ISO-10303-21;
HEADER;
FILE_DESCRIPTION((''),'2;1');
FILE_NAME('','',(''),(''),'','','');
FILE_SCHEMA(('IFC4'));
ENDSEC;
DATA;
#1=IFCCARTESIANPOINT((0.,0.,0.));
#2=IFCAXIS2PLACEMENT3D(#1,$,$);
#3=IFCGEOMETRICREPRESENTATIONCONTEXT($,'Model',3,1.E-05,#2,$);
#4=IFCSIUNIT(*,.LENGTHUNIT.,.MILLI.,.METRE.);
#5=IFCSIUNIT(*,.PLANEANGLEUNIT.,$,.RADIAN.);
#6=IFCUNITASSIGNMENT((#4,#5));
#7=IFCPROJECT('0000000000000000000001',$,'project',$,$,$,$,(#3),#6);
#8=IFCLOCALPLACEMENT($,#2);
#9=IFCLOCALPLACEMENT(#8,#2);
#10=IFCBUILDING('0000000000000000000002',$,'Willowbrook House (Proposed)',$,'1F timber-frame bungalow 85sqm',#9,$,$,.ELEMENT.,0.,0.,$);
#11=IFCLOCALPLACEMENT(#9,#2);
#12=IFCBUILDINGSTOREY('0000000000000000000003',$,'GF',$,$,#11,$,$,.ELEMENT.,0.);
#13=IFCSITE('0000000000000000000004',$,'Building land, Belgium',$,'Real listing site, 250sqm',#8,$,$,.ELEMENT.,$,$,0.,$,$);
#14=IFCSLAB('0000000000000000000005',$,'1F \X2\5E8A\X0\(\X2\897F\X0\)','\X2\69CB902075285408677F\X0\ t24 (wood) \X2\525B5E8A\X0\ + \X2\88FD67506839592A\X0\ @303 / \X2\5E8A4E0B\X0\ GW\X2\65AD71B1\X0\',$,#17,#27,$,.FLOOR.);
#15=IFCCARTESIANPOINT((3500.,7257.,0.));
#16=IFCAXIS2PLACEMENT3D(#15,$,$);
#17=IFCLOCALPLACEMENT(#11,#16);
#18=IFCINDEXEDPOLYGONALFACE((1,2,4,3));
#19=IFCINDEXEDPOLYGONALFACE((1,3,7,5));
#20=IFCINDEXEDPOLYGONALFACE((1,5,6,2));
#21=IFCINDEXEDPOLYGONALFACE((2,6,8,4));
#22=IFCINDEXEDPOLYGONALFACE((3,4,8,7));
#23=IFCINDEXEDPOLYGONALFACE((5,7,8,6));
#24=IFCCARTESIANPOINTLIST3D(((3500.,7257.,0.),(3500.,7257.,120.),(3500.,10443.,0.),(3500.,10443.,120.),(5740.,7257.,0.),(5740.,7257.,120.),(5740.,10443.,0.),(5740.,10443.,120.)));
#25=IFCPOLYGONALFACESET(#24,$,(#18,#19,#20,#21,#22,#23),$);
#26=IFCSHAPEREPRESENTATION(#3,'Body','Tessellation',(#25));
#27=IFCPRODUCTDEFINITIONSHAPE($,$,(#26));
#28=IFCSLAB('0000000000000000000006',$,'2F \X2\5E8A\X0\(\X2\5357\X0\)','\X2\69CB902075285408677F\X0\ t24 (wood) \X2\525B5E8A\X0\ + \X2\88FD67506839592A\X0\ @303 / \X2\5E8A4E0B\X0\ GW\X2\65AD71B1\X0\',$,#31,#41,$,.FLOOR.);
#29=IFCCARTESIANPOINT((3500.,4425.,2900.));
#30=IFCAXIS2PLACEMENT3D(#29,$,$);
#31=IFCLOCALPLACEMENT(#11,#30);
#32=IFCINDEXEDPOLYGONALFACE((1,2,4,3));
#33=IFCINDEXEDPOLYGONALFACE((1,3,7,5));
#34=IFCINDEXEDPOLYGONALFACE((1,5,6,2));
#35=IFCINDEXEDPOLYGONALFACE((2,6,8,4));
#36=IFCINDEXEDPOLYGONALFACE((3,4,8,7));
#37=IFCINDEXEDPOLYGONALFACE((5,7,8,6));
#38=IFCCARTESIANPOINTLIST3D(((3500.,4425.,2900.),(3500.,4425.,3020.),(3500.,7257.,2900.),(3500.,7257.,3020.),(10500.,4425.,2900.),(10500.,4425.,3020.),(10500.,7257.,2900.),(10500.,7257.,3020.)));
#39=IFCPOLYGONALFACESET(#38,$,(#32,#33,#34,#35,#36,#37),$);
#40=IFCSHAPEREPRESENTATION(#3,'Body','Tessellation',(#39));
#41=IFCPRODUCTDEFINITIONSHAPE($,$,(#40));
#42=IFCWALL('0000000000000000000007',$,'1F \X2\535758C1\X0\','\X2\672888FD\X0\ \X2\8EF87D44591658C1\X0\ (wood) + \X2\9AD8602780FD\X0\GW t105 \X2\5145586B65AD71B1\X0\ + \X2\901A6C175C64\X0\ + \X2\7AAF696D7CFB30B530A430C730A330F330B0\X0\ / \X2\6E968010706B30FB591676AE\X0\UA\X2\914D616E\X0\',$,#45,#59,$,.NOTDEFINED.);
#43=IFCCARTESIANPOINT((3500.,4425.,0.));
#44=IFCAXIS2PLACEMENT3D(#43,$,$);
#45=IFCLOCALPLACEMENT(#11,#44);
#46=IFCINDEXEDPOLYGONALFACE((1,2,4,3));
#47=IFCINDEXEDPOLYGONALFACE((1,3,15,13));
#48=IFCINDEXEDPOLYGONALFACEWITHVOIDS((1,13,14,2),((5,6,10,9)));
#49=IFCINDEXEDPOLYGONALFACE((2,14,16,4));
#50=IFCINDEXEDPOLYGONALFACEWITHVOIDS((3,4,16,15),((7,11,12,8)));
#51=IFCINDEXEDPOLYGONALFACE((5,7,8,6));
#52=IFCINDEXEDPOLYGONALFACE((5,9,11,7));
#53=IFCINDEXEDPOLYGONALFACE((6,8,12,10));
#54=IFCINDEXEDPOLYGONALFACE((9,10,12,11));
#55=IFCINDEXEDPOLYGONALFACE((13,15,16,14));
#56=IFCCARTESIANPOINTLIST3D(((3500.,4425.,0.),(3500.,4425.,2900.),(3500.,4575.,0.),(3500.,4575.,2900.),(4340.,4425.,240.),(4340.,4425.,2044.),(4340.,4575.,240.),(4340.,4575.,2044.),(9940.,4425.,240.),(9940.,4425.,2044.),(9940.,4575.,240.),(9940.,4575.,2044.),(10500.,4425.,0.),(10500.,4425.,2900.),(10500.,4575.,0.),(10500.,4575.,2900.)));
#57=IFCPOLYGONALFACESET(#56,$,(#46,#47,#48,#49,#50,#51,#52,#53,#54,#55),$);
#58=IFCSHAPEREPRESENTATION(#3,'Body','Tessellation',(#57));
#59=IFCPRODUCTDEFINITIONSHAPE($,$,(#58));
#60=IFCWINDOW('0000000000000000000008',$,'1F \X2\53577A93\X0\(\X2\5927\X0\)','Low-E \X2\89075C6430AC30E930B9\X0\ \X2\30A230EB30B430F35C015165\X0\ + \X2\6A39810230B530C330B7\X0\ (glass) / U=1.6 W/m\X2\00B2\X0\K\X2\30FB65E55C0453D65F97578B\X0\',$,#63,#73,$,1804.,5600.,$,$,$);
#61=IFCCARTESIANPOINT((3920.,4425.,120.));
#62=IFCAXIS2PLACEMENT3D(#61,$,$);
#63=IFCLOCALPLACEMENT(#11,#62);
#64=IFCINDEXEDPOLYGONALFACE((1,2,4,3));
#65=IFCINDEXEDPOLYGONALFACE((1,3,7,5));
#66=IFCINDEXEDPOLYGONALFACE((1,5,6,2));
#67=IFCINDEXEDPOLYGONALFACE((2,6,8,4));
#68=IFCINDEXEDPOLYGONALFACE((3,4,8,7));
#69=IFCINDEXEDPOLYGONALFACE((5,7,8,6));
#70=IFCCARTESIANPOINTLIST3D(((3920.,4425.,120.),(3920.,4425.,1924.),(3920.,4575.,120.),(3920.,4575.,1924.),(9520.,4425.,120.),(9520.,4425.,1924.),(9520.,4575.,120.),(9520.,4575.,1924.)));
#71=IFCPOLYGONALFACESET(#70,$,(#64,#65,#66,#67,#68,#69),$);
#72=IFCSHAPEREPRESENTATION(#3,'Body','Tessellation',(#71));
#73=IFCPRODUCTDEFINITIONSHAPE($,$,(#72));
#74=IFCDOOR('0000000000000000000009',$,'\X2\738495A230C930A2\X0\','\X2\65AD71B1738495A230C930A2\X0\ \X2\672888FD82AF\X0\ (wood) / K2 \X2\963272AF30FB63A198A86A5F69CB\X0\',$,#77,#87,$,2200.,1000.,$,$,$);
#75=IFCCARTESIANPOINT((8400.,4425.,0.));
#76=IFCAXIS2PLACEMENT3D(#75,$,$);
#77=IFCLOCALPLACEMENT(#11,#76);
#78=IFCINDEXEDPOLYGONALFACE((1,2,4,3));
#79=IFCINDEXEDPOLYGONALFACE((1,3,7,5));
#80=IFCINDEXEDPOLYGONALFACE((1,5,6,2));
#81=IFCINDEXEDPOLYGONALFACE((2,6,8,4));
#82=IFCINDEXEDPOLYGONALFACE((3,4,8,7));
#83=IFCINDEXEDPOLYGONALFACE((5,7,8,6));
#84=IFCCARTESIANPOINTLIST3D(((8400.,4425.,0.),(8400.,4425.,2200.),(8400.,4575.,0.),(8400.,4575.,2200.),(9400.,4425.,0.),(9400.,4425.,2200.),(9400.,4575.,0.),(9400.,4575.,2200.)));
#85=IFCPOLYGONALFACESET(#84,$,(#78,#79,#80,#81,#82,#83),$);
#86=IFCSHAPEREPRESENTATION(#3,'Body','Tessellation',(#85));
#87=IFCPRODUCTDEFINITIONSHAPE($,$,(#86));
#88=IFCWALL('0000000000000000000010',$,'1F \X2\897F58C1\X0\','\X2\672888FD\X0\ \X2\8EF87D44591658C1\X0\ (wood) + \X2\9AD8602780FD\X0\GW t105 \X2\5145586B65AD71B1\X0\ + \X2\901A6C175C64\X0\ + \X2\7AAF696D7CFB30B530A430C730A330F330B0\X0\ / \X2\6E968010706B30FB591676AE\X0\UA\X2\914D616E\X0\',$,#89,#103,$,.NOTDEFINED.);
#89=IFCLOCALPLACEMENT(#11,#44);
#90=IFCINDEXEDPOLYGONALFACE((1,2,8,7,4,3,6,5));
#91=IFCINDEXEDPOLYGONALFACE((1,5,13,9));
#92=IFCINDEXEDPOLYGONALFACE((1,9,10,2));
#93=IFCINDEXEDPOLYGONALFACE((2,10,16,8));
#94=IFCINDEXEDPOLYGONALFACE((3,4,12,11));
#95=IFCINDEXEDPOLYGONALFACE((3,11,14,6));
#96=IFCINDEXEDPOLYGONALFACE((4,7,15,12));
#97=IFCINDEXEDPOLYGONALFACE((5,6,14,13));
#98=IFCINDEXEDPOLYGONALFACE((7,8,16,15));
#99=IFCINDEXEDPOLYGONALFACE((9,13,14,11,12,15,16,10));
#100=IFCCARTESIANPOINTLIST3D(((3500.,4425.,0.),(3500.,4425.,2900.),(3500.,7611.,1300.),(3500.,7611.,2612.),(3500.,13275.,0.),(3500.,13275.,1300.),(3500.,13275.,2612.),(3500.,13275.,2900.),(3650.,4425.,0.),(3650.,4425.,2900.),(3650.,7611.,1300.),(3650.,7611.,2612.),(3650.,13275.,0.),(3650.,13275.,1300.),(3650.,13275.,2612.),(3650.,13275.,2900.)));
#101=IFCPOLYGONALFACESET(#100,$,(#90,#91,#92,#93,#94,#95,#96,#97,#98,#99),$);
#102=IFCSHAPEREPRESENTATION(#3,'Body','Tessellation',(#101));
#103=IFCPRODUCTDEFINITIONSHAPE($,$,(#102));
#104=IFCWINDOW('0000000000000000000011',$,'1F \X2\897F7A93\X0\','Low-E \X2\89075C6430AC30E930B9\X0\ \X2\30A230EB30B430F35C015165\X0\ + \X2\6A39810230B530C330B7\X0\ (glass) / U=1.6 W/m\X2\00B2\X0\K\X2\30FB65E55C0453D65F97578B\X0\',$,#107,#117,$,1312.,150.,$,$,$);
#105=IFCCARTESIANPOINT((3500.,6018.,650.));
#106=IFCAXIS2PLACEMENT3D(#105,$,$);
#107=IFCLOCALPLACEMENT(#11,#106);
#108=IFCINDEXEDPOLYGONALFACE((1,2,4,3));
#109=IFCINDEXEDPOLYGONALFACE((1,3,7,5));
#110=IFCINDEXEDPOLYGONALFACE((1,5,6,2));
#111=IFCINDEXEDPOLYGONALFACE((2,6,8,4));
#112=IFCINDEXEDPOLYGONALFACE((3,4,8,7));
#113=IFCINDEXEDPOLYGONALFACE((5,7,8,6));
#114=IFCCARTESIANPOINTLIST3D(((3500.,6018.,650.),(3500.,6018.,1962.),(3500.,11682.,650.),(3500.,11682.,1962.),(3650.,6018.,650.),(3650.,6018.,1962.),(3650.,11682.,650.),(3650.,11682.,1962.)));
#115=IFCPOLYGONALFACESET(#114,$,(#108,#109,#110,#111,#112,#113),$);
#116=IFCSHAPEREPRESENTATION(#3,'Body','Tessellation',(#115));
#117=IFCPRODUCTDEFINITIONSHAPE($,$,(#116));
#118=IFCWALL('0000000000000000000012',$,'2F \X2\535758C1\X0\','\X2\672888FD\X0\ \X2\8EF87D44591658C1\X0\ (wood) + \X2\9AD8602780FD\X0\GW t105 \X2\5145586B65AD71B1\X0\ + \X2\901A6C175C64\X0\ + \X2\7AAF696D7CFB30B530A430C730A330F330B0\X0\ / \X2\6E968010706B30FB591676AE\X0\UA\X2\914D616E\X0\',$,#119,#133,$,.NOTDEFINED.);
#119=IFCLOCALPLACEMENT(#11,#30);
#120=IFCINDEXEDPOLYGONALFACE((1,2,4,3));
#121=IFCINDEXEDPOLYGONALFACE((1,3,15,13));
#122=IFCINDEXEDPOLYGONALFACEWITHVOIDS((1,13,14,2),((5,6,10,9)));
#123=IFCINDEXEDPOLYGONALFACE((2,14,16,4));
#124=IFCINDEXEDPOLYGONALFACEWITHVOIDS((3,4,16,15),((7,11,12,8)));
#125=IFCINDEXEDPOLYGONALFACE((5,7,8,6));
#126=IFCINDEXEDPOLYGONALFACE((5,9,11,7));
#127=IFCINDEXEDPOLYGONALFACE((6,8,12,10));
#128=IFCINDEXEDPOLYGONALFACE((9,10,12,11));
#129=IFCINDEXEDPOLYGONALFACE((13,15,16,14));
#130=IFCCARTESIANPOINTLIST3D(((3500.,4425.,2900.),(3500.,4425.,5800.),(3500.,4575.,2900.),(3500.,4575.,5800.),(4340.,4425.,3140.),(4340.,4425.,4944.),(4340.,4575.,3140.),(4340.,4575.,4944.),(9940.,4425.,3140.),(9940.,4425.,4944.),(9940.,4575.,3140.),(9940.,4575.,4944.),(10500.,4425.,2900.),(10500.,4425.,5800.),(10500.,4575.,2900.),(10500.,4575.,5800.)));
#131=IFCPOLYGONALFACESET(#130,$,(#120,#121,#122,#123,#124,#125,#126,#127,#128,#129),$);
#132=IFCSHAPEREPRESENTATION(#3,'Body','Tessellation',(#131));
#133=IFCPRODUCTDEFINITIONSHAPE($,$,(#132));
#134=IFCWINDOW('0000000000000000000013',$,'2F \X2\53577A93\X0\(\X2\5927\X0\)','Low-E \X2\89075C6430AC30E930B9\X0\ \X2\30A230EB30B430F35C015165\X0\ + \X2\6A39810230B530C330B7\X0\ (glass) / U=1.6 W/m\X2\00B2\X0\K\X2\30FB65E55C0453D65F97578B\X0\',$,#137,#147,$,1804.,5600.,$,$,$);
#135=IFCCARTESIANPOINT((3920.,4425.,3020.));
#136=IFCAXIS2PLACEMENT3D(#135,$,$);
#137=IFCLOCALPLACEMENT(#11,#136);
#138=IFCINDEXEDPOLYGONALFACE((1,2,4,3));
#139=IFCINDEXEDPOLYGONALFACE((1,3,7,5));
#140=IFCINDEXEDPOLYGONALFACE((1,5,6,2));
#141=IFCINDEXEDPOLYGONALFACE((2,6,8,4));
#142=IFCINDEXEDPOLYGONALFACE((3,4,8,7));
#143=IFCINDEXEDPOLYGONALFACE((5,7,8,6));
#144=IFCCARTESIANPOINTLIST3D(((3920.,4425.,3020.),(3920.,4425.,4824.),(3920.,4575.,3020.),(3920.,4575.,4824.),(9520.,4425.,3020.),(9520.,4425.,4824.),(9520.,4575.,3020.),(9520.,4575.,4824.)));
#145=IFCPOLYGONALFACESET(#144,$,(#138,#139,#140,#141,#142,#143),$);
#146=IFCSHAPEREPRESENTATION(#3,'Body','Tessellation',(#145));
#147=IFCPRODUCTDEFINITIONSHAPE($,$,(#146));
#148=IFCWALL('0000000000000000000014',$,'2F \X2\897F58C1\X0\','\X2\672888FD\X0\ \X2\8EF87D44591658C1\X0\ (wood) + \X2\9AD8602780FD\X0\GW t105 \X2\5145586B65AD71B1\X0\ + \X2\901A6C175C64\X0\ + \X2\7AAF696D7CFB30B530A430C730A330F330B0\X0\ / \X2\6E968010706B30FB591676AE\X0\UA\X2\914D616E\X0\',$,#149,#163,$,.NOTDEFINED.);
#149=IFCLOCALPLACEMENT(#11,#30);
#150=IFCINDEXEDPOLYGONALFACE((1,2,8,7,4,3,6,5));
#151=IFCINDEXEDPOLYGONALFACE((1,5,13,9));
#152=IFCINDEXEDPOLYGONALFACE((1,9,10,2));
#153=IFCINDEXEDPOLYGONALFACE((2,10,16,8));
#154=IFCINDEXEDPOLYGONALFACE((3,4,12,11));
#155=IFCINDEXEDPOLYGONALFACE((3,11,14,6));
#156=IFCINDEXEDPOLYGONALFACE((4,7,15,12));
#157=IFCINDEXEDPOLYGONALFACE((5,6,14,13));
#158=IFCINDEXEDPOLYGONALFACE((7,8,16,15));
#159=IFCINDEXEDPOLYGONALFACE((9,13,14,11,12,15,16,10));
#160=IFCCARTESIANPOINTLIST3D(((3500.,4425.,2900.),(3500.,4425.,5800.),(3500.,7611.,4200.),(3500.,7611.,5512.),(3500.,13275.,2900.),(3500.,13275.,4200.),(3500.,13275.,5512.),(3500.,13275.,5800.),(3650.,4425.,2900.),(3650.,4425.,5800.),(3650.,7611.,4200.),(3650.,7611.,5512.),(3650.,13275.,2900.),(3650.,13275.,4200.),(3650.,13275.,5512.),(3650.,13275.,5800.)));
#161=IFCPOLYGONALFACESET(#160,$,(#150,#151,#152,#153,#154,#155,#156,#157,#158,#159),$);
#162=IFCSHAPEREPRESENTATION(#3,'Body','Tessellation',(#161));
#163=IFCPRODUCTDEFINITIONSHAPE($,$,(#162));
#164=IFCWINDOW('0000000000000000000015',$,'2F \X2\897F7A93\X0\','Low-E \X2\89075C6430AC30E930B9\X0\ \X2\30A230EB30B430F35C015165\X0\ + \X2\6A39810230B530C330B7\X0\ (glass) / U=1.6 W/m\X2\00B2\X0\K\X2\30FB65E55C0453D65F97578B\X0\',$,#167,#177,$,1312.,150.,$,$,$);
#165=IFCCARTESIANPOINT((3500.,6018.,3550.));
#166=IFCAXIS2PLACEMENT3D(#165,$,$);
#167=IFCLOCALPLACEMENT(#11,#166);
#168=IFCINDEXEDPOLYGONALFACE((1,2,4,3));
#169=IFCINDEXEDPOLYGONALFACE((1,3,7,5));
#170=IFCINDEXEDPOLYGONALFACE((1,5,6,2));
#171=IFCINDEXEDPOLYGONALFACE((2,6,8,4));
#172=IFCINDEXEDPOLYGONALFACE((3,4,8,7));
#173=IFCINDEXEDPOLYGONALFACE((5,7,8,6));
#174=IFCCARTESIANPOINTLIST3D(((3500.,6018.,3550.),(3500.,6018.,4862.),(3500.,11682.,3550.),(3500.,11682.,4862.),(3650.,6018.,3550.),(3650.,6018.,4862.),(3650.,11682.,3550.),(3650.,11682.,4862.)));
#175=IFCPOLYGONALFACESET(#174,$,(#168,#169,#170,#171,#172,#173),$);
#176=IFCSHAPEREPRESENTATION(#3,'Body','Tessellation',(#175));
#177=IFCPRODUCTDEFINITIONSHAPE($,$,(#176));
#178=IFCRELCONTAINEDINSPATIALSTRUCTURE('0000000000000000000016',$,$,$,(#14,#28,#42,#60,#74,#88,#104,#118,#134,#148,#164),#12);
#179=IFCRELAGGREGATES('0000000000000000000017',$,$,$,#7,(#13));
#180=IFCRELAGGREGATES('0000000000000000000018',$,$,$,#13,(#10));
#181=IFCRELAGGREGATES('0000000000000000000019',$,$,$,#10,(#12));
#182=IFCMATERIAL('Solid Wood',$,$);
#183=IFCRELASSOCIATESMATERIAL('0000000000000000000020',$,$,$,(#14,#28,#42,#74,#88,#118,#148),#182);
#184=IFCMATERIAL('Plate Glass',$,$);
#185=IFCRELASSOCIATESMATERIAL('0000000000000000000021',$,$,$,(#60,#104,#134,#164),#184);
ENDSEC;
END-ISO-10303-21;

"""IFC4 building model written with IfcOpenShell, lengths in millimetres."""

from ifc_helpers import new_model, si_unit, frame, frame_2d, origin, place, context, project, spatial, rectangle, extrude, material, element, fill, save


model = new_model("IFC4")

# Units and contexts
model_context = context("Model", 3, precision=1e-05, world=origin())
ifc_project = project(units=[si_unit("LENGTHUNIT", "METRE", prefix="MILLI"), si_unit("PLANEANGLEUNIT", "RADIAN")], contexts=[model_context])

# Site, building, storey
site_placement = place(None, origin())
site = spatial("IfcSite", under=ifc_project, at=site_placement, Name="Building land, Belgium", ObjectType="Real listing site, 250sqm", CompositionType="ELEMENT", RefElevation=0.0)
building_placement = place(site_placement, origin())
building = spatial("IfcBuilding", under=site, at=building_placement, Name="Willowbrook House (Proposed)", ObjectType="1F timber-frame bungalow 85sqm", CompositionType="ELEMENT", ElevationOfRefHeight=0.0, ElevationOfTerrain=0.0)
storey_placement = place(building_placement, origin())
storey = spatial("IfcBuildingStorey", under=building, at=storey_placement, Name="GF", CompositionType="ELEMENT", Elevation=0.0)

# Slabs
ifc_material_1 = material(Name="Solid Wood")
slab_1_placement = place(storey_placement, frame((3500.0, 7257.0, 0.0)))
element("IfcSlab", 1, at=slab_1_placement, inside=storey, material=ifc_material_1, Name="1F 床(西)", Description="構造用合板 t24 (wood) 剛床 + 製材根太 @303 / 床下 GW断熱", PredefinedType="FLOOR", context=model_context, shape_type="SweptSolid", body=[
    extrude(rectangle(XDim=2240.0, YDim=3186.0, at=frame_2d((1120.0, 1593.0))), frame((3500.0, 7257.0, 0.0)), (0.0, 0.0, 1.0), 120.0),
])
slab_2_placement = place(storey_placement, frame((3500.0, 4425.0, 2900.0)))
element("IfcSlab", 2, at=slab_2_placement, inside=storey, material=ifc_material_1, Name="2F 床(南)", Description="構造用合板 t24 (wood) 剛床 + 製材根太 @303 / 床下 GW断熱", PredefinedType="FLOOR", context=model_context, shape_type="SweptSolid", body=[
    extrude(rectangle(XDim=7000.0, YDim=2832.0, at=frame_2d((3500.0, 1416.0))), frame((3500.0, 4425.0, 2900.0)), (0.0, 0.0, 1.0), 120.0),
])

# Wall, openings, window, door
wall_1_placement = place(storey_placement, frame((3500.0, 4425.0, 0.0)))
wall_1 = element("IfcWall", 3, at=wall_1_placement, inside=storey, material=ifc_material_1, Name="1F 南壁", Description="木製 軸組外壁 (wood) + 高性能GW t105 充填断熱 + 通気層 + 窯業系サイディング / 準耐火・外皮UA配慮", PredefinedType="NOTDEFINED", context=model_context, shape_type="SweptSolid", body=[
    extrude(rectangle(XDim=7000.0, YDim=150.0, at=frame_2d((3500.0, 75.0))), frame((3500.0, 4425.0, 0.0)), (0.0, 0.0, 1.0), 2900.0),
])
opening_1_placement = place(storey_placement, frame((3920.0, 4425.0, 120.0)))
opening_1 = element("IfcOpeningElement", 4, at=opening_1_placement, cuts=wall_1, PredefinedType="NOTDEFINED", context=model_context, shape_type="SweptSolid", body=[
    extrude(rectangle(XDim=5600.0, YDim=150.0, at=frame_2d((2800.0, 75.0))), frame((3920.0, 4425.0, 120.0)), (0.0, 0.0, 1.0), 1804.0),
])
opening_2_placement = place(storey_placement, frame((8400.0, 4425.0, 0.0)))
opening_2 = element("IfcOpeningElement", 5, at=opening_2_placement, cuts=wall_1, PredefinedType="NOTDEFINED", context=model_context, shape_type="SweptSolid", body=[
    extrude(rectangle(XDim=1000.0, YDim=150.0, at=frame_2d((500.0, 75.0))), frame((8400.0, 4425.0, 0.0)), (0.0, 0.0, 1.0), 2200.0),
])
ifc_material_2 = material(Name="Plate Glass")
window_1_placement = place(storey_placement, frame((3920.0, 4425.0, 120.0)))
window_1 = element("IfcWindow", 6, at=window_1_placement, inside=storey, material=ifc_material_2, Name="1F 南窓(大)", Description="Low-E 複層ガラス アルゴン封入 + 樹脂サッシ (glass) / U=1.6 W/m²K・日射取得型", OverallHeight=1804.0, OverallWidth=5600.0, context=model_context, shape_type="SweptSolid", body=[
    extrude(rectangle(XDim=5600.0, YDim=150.0, at=frame_2d((2800.0, 75.0))), frame((3920.0, 4425.0, 120.0)), (0.0, 0.0, 1.0), 1804.0),
])
fill(opening_1, window_1)
door_placement = place(storey_placement, frame((8400.0, 4425.0, 0.0)))
door = element("IfcDoor", 7, at=door_placement, inside=storey, material=ifc_material_1, Name="玄関ドア", Description="断熱玄関ドア 木製芯 (wood) / K2 防犯・採風機構", OverallHeight=2200.0, OverallWidth=1000.0, context=model_context, shape_type="SweptSolid", body=[
    extrude(rectangle(XDim=1000.0, YDim=150.0, at=frame_2d((500.0, 75.0))), frame((8400.0, 4425.0, 0.0)), (0.0, 0.0, 1.0), 2200.0),
])
fill(opening_2, door)

# Walls, openings, windows
wall_2_placement = place(storey_placement, frame((3500.0, 4425.0, 0.0)))
wall_2 = element("IfcWall", 8, at=wall_2_placement, inside=storey, material=ifc_material_1, Name="1F 西壁", Description="木製 軸組外壁 (wood) + 高性能GW t105 充填断熱 + 通気層 + 窯業系サイディング / 準耐火・外皮UA配慮", PredefinedType="NOTDEFINED", context=model_context, shape_type="SweptSolid", body=[
    extrude(rectangle(XDim=150.0, YDim=8850.0, at=frame_2d((75.0, 4425.0))), frame((3500.0, 4425.0, 0.0)), (0.0, 0.0, 1.0), 2900.0),
])
opening_3_placement = place(storey_placement, frame((3500.0, 6018.0, 650.0)))
opening_3 = element("IfcOpeningElement", 9, at=opening_3_placement, cuts=wall_2, PredefinedType="NOTDEFINED", context=model_context, shape_type="SweptSolid", body=[
    extrude(rectangle(XDim=150.0, YDim=5664.0, at=frame_2d((75.0, 2832.0))), frame((3500.0, 6018.0, 650.0)), (0.0, 0.0, 1.0), 1312.0),
])
window_2_placement = place(storey_placement, frame((3500.0, 6018.0, 650.0)))
window_2 = element("IfcWindow", 10, at=window_2_placement, inside=storey, material=ifc_material_2, Name="1F 西窓", Description="Low-E 複層ガラス アルゴン封入 + 樹脂サッシ (glass) / U=1.6 W/m²K・日射取得型", OverallHeight=1312.0, OverallWidth=150.0, context=model_context, shape_type="SweptSolid", body=[
    extrude(rectangle(XDim=150.0, YDim=5664.0, at=frame_2d((75.0, 2832.0))), frame((3500.0, 6018.0, 650.0)), (0.0, 0.0, 1.0), 1312.0),
])
fill(opening_3, window_2)
wall_3_placement = place(storey_placement, frame((3500.0, 4425.0, 2900.0)))
wall_3 = element("IfcWall", 11, at=wall_3_placement, inside=storey, material=ifc_material_1, Name="2F 南壁", Description="木製 軸組外壁 (wood) + 高性能GW t105 充填断熱 + 通気層 + 窯業系サイディング / 準耐火・外皮UA配慮", PredefinedType="NOTDEFINED", context=model_context, shape_type="SweptSolid", body=[
    extrude(rectangle(XDim=7000.0, YDim=150.0, at=frame_2d((3500.0, 75.0))), frame((3500.0, 4425.0, 2900.0)), (0.0, 0.0, 1.0), 2900.0),
])
opening_4_placement = place(storey_placement, frame((3920.0, 4425.0, 3020.0)))
opening_4 = element("IfcOpeningElement", 12, at=opening_4_placement, cuts=wall_3, PredefinedType="NOTDEFINED", context=model_context, shape_type="SweptSolid", body=[
    extrude(rectangle(XDim=5600.0, YDim=150.0, at=frame_2d((2800.0, 75.0))), frame((3920.0, 4425.0, 3020.0)), (0.0, 0.0, 1.0), 1804.0),
])
window_3_placement = place(storey_placement, frame((3920.0, 4425.0, 3020.0)))
window_3 = element("IfcWindow", 13, at=window_3_placement, inside=storey, material=ifc_material_2, Name="2F 南窓(大)", Description="Low-E 複層ガラス アルゴン封入 + 樹脂サッシ (glass) / U=1.6 W/m²K・日射取得型", OverallHeight=1804.0, OverallWidth=5600.0, context=model_context, shape_type="SweptSolid", body=[
    extrude(rectangle(XDim=5600.0, YDim=150.0, at=frame_2d((2800.0, 75.0))), frame((3920.0, 4425.0, 3020.0)), (0.0, 0.0, 1.0), 1804.0),
])
fill(opening_4, window_3)
wall_4_placement = place(storey_placement, frame((3500.0, 4425.0, 2900.0)))
wall_4 = element("IfcWall", 14, at=wall_4_placement, inside=storey, material=ifc_material_1, Name="2F 西壁", Description="木製 軸組外壁 (wood) + 高性能GW t105 充填断熱 + 通気層 + 窯業系サイディング / 準耐火・外皮UA配慮", PredefinedType="NOTDEFINED", context=model_context, shape_type="SweptSolid", body=[
    extrude(rectangle(XDim=150.0, YDim=8850.0, at=frame_2d((75.0, 4425.0))), frame((3500.0, 4425.0, 2900.0)), (0.0, 0.0, 1.0), 2900.0),
])
opening_5_placement = place(storey_placement, frame((3500.0, 6018.0, 3550.0)))
opening_5 = element("IfcOpeningElement", 15, at=opening_5_placement, cuts=wall_4, PredefinedType="NOTDEFINED", context=model_context, shape_type="SweptSolid", body=[
    extrude(rectangle(XDim=150.0, YDim=5664.0, at=frame_2d((75.0, 2832.0))), frame((3500.0, 6018.0, 3550.0)), (0.0, 0.0, 1.0), 1312.0),
])
window_4_placement = place(storey_placement, frame((3500.0, 6018.0, 3550.0)))
window_4 = element("IfcWindow", 16, at=window_4_placement, inside=storey, material=ifc_material_2, Name="2F 西窓", Description="Low-E 複層ガラス アルゴン封入 + 樹脂サッシ (glass) / U=1.6 W/m²K・日射取得型", OverallHeight=1312.0, OverallWidth=150.0, context=model_context, shape_type="SweptSolid", body=[
    extrude(rectangle(XDim=150.0, YDim=5664.0, at=frame_2d((75.0, 2832.0))), frame((3500.0, 6018.0, 3550.0)), (0.0, 0.0, 1.0), 1312.0),
])
fill(opening_5, window_4)

save(model, "model.ifc")
